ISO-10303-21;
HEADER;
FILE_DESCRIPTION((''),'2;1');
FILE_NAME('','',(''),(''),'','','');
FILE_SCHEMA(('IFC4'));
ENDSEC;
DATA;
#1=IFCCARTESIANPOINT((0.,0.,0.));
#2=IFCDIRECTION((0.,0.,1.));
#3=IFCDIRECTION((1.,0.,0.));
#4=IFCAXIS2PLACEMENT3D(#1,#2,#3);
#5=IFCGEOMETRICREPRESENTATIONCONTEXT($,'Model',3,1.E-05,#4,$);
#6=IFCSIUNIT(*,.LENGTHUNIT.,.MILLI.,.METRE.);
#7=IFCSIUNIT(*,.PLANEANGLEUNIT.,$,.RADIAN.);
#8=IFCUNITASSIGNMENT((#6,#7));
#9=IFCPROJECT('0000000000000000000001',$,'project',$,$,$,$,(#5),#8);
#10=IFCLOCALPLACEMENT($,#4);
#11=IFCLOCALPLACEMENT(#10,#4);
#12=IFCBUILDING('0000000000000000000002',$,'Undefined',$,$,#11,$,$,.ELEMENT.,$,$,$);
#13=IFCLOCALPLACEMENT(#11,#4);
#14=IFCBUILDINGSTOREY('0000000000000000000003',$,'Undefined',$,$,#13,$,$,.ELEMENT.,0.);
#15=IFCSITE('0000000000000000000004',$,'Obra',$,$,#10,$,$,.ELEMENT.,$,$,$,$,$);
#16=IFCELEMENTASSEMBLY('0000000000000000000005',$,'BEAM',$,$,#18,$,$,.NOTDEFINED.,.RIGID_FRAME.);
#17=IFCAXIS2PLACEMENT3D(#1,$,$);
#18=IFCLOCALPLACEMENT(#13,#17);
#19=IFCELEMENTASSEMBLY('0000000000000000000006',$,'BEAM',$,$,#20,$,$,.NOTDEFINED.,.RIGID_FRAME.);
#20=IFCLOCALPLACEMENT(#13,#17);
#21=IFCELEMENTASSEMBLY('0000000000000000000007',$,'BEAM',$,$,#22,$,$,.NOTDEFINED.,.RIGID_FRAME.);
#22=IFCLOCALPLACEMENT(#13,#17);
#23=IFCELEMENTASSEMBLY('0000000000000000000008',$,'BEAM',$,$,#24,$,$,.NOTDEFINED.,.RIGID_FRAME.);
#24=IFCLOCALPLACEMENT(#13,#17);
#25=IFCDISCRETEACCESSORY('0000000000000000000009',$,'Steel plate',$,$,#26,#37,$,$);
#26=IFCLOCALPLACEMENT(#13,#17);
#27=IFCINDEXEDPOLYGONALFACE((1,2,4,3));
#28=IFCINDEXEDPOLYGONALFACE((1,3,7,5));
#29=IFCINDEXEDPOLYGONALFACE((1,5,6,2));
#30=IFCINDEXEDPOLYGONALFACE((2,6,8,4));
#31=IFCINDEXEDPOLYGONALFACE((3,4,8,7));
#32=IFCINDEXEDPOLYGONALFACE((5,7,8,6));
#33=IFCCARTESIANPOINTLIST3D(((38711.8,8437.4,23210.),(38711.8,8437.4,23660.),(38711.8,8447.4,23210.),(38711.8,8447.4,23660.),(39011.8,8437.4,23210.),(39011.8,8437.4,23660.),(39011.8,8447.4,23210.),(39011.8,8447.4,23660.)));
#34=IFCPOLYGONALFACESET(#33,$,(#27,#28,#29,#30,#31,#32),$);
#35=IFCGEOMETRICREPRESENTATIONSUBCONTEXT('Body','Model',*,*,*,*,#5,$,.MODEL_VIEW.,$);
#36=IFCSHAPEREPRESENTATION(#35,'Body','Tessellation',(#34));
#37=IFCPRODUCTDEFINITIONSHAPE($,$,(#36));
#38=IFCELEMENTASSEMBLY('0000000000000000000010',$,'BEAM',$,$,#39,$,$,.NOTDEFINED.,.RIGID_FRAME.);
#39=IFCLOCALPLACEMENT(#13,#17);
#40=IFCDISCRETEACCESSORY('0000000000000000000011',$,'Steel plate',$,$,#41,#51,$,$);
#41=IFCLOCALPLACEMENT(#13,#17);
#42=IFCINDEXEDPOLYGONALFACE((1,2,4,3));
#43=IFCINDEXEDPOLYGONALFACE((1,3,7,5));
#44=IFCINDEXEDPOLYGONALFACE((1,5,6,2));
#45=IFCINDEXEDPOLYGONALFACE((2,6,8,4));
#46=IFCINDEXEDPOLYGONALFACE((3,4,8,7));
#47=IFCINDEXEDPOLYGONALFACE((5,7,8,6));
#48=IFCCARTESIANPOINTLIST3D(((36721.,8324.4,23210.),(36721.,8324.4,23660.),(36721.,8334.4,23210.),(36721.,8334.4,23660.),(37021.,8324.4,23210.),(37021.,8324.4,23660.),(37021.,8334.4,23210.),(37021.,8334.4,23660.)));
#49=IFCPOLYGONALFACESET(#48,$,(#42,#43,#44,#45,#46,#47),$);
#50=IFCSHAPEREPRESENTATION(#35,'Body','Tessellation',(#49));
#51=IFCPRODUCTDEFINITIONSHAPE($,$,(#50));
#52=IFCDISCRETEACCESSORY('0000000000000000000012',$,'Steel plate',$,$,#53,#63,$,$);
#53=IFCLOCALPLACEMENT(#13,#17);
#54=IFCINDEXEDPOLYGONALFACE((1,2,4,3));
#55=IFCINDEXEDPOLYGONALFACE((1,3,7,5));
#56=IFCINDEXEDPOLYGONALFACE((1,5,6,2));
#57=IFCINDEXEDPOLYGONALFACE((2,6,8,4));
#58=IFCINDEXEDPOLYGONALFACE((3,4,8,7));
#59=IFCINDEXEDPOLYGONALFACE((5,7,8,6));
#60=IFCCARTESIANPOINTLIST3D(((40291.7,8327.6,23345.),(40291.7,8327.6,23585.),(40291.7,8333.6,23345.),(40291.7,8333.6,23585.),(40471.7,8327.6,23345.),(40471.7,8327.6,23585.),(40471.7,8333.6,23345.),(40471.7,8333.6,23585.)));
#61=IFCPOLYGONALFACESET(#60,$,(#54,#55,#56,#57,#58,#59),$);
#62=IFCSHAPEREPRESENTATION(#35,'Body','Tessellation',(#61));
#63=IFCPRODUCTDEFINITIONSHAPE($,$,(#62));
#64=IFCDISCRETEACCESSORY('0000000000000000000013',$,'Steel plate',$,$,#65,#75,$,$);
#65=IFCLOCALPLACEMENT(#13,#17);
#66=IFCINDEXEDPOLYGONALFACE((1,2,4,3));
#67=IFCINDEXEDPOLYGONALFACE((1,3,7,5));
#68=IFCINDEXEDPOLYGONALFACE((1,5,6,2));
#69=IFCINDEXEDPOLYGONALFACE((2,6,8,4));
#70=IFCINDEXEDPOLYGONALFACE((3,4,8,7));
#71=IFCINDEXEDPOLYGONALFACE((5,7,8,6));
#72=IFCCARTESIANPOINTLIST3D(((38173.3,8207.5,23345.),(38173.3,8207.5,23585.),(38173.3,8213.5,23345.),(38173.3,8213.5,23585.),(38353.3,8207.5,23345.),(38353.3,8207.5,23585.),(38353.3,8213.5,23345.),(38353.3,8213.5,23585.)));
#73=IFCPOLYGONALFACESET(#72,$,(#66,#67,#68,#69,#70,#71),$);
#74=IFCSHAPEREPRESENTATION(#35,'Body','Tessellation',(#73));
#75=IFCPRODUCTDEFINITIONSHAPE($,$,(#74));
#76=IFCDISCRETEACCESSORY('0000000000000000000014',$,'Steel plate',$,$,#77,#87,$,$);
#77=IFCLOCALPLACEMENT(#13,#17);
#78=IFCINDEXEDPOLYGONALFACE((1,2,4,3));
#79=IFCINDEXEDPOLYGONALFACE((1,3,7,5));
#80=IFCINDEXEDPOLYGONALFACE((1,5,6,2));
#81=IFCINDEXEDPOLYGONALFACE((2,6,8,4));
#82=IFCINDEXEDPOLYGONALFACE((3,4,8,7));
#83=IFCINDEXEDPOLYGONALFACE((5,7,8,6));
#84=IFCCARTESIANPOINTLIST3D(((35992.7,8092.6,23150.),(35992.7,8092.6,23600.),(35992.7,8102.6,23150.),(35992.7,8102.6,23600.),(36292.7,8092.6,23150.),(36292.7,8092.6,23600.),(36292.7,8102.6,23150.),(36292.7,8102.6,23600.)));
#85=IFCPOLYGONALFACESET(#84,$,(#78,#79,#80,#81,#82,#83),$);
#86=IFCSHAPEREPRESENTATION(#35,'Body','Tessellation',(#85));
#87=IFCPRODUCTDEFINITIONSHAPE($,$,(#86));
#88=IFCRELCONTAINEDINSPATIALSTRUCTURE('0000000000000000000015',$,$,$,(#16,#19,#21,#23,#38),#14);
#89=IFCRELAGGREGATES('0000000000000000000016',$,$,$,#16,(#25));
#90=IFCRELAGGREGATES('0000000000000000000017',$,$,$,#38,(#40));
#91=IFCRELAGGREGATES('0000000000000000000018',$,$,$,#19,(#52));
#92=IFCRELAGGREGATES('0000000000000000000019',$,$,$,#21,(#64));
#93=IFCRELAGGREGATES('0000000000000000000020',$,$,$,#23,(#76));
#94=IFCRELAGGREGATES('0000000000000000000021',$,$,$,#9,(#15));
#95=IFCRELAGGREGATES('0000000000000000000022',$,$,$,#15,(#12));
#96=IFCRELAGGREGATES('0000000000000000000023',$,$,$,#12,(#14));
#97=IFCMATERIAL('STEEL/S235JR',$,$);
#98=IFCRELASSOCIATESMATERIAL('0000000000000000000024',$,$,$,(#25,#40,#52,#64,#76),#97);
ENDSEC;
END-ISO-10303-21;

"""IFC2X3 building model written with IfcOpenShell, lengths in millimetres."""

from ifc_helpers import new_model, si_unit, frame, origin_with_axes, place, context, subcontext, project, spatial, polyline, outline, extrude, material, element, aggregate, save


model = new_model("IFC2X3")

# Units and contexts
model_context = context("Model", 3, precision=1e-05, world=origin_with_axes())
body_context = subcontext(model_context, "Body", "Model", "MODEL_VIEW")
ifc_project = project(units=[si_unit("LENGTHUNIT", "METRE", prefix="MILLI"), si_unit("PLANEANGLEUNIT", "RADIAN")], contexts=[model_context])

# Site, building, storey
site_placement = place(None, origin_with_axes())
site = spatial("IfcSite", under=ifc_project, at=site_placement, Name="Obra", CompositionType="ELEMENT")
building_placement = place(site_placement, origin_with_axes())
building = spatial("IfcBuilding", under=site, at=building_placement, Name="Undefined", CompositionType="ELEMENT")
storey_placement = place(building_placement, origin_with_axes())
storey = spatial("IfcBuildingStorey", under=building, at=storey_placement, Name="Undefined", CompositionType="ELEMENT", Elevation=0.0)

# Element assembly
ifc_material_1 = material(Name="STEEL/S235JR")
assembly_1_placement = place(storey_placement, origin_with_axes())
assembly_1 = element("IfcElementAssembly", 1, at=assembly_1_placement, inside=storey, Name="BEAM", AssemblyPlace="NOTDEFINED", PredefinedType="RIGID_FRAME")

# Element assemblies
assembly_2_placement = place(storey_placement, origin_with_axes())
assembly_2 = element("IfcElementAssembly", 2, at=assembly_2_placement, inside=storey, Name="BEAM", AssemblyPlace="NOTDEFINED", PredefinedType="RIGID_FRAME")
assembly_3_placement = place(storey_placement, origin_with_axes())
assembly_3 = element("IfcElementAssembly", 3, at=assembly_3_placement, inside=storey, Name="BEAM", AssemblyPlace="NOTDEFINED", PredefinedType="RIGID_FRAME")
assembly_4_placement = place(storey_placement, origin_with_axes())
assembly_4 = element("IfcElementAssembly", 4, at=assembly_4_placement, inside=storey, Name="BEAM", AssemblyPlace="NOTDEFINED", PredefinedType="RIGID_FRAME")

# Discrete accessory
discrete_accessory_1_placement = place(assembly_1_placement, frame((38711.8, 8442.4, 23660.0), z_axis=(0.000002, -1.0, 0.0), x_axis=(0.0, 0.0, -1.0)))
discrete_accessory_1 = element("IfcDiscreteAccessory", 5, at=discrete_accessory_1_placement, material=ifc_material_1, Name="Steel plate", context=body_context, shape_type="SweptSolid", body=[
    extrude(outline(polyline([(0.0, 0.0), (450.0, 0.0), (450.0, 300.0), (0.0, 300.0), (0.0, 0.0)])), frame((0.0, 0.0, -5.0), z_axis=(0.0, 0.0, 1.0), x_axis=(1.0, 0.0, 0.0)), (0.0, 0.0, 1.0), 10.0),
])
aggregate(assembly_1, [discrete_accessory_1])

# Element assembly, discrete accessory
assembly_5_placement = place(storey_placement, origin_with_axes())
assembly_5 = element("IfcElementAssembly", 6, at=assembly_5_placement, inside=storey, Name="BEAM", AssemblyPlace="NOTDEFINED", PredefinedType="RIGID_FRAME")
discrete_accessory_2_placement = place(assembly_5_placement, frame((36721.0, 8329.4, 23660.0), z_axis=(0.0, -1.0, 0.0), x_axis=(0.0, 0.0, -1.0)))
discrete_accessory_2 = element("IfcDiscreteAccessory", 7, at=discrete_accessory_2_placement, material=ifc_material_1, Name="Steel plate", context=body_context, shape_type="SweptSolid", body=[
    extrude(outline(polyline([(0.0, 0.0), (450.0, 0.0), (450.0, 300.0), (0.0, 300.0), (0.0, 0.0)])), frame((0.0, 0.0, -5.0), z_axis=(0.0, 0.0, 1.0), x_axis=(1.0, 0.0, 0.0)), (0.0, 0.0, 1.0), 10.0),
])
aggregate(assembly_5, [discrete_accessory_2])

# Discrete accessories
discrete_accessory_3_placement = place(assembly_2_placement, frame((40471.7, 8330.6, 23585.0), z_axis=(0.0, -1.0, 0.0), x_axis=(-1.0, 0.0, 0.0)))
discrete_accessory_3 = element("IfcDiscreteAccessory", 8, at=discrete_accessory_3_placement, material=ifc_material_1, Name="Steel plate", context=body_context, shape_type="SweptSolid", body=[
    extrude(outline(polyline([(0.0, 0.0), (180.0, 0.0), (180.0, 240.0), (0.0, 240.0), (0.0, 0.0)])), frame((0.0, 0.0, -3.0), z_axis=(0.0, 0.0, 1.0), x_axis=(1.0, 0.0, 0.0)), (0.0, 0.0, 1.0), 6.0),
])
aggregate(assembly_2, [discrete_accessory_3])
discrete_accessory_4_placement = place(assembly_3_placement, frame((38353.3, 8210.5, 23585.0), z_axis=(0.0, -1.0, 0.0), x_axis=(-1.0, 0.0, 0.0)))
discrete_accessory_4 = element("IfcDiscreteAccessory", 9, at=discrete_accessory_4_placement, material=ifc_material_1, Name="Steel plate", context=body_context, shape_type="SweptSolid", body=[
    extrude(outline(polyline([(0.0, 0.0), (180.0, 0.0), (180.0, 240.0), (0.0, 240.0), (0.0, 0.0)])), frame((0.0, 0.0, -3.0), z_axis=(0.0, 0.0, 1.0), x_axis=(1.0, 0.0, 0.0)), (0.0, 0.0, 1.0), 6.0),
])
aggregate(assembly_3, [discrete_accessory_4])
discrete_accessory_5_placement = place(assembly_4_placement, frame((36292.7, 8097.6, 23600.0), z_axis=(0.0, 1.0, 0.0), x_axis=(0.0, 0.0, -1.0)))
discrete_accessory_5 = element("IfcDiscreteAccessory", 10, at=discrete_accessory_5_placement, material=ifc_material_1, Name="Steel plate", context=body_context, shape_type="SweptSolid", body=[
    extrude(outline(polyline([(0.0, 0.0), (450.0, 0.0), (450.0, 300.0), (0.0, 300.0), (0.0, 0.0)])), frame((0.0, 0.0, -5.0), z_axis=(0.0, 0.0, 1.0), x_axis=(1.0, 0.0, 0.0)), (0.0, 0.0, 1.0), 10.0),
])
aggregate(assembly_4, [discrete_accessory_5])

save(model, "model.ifc")
